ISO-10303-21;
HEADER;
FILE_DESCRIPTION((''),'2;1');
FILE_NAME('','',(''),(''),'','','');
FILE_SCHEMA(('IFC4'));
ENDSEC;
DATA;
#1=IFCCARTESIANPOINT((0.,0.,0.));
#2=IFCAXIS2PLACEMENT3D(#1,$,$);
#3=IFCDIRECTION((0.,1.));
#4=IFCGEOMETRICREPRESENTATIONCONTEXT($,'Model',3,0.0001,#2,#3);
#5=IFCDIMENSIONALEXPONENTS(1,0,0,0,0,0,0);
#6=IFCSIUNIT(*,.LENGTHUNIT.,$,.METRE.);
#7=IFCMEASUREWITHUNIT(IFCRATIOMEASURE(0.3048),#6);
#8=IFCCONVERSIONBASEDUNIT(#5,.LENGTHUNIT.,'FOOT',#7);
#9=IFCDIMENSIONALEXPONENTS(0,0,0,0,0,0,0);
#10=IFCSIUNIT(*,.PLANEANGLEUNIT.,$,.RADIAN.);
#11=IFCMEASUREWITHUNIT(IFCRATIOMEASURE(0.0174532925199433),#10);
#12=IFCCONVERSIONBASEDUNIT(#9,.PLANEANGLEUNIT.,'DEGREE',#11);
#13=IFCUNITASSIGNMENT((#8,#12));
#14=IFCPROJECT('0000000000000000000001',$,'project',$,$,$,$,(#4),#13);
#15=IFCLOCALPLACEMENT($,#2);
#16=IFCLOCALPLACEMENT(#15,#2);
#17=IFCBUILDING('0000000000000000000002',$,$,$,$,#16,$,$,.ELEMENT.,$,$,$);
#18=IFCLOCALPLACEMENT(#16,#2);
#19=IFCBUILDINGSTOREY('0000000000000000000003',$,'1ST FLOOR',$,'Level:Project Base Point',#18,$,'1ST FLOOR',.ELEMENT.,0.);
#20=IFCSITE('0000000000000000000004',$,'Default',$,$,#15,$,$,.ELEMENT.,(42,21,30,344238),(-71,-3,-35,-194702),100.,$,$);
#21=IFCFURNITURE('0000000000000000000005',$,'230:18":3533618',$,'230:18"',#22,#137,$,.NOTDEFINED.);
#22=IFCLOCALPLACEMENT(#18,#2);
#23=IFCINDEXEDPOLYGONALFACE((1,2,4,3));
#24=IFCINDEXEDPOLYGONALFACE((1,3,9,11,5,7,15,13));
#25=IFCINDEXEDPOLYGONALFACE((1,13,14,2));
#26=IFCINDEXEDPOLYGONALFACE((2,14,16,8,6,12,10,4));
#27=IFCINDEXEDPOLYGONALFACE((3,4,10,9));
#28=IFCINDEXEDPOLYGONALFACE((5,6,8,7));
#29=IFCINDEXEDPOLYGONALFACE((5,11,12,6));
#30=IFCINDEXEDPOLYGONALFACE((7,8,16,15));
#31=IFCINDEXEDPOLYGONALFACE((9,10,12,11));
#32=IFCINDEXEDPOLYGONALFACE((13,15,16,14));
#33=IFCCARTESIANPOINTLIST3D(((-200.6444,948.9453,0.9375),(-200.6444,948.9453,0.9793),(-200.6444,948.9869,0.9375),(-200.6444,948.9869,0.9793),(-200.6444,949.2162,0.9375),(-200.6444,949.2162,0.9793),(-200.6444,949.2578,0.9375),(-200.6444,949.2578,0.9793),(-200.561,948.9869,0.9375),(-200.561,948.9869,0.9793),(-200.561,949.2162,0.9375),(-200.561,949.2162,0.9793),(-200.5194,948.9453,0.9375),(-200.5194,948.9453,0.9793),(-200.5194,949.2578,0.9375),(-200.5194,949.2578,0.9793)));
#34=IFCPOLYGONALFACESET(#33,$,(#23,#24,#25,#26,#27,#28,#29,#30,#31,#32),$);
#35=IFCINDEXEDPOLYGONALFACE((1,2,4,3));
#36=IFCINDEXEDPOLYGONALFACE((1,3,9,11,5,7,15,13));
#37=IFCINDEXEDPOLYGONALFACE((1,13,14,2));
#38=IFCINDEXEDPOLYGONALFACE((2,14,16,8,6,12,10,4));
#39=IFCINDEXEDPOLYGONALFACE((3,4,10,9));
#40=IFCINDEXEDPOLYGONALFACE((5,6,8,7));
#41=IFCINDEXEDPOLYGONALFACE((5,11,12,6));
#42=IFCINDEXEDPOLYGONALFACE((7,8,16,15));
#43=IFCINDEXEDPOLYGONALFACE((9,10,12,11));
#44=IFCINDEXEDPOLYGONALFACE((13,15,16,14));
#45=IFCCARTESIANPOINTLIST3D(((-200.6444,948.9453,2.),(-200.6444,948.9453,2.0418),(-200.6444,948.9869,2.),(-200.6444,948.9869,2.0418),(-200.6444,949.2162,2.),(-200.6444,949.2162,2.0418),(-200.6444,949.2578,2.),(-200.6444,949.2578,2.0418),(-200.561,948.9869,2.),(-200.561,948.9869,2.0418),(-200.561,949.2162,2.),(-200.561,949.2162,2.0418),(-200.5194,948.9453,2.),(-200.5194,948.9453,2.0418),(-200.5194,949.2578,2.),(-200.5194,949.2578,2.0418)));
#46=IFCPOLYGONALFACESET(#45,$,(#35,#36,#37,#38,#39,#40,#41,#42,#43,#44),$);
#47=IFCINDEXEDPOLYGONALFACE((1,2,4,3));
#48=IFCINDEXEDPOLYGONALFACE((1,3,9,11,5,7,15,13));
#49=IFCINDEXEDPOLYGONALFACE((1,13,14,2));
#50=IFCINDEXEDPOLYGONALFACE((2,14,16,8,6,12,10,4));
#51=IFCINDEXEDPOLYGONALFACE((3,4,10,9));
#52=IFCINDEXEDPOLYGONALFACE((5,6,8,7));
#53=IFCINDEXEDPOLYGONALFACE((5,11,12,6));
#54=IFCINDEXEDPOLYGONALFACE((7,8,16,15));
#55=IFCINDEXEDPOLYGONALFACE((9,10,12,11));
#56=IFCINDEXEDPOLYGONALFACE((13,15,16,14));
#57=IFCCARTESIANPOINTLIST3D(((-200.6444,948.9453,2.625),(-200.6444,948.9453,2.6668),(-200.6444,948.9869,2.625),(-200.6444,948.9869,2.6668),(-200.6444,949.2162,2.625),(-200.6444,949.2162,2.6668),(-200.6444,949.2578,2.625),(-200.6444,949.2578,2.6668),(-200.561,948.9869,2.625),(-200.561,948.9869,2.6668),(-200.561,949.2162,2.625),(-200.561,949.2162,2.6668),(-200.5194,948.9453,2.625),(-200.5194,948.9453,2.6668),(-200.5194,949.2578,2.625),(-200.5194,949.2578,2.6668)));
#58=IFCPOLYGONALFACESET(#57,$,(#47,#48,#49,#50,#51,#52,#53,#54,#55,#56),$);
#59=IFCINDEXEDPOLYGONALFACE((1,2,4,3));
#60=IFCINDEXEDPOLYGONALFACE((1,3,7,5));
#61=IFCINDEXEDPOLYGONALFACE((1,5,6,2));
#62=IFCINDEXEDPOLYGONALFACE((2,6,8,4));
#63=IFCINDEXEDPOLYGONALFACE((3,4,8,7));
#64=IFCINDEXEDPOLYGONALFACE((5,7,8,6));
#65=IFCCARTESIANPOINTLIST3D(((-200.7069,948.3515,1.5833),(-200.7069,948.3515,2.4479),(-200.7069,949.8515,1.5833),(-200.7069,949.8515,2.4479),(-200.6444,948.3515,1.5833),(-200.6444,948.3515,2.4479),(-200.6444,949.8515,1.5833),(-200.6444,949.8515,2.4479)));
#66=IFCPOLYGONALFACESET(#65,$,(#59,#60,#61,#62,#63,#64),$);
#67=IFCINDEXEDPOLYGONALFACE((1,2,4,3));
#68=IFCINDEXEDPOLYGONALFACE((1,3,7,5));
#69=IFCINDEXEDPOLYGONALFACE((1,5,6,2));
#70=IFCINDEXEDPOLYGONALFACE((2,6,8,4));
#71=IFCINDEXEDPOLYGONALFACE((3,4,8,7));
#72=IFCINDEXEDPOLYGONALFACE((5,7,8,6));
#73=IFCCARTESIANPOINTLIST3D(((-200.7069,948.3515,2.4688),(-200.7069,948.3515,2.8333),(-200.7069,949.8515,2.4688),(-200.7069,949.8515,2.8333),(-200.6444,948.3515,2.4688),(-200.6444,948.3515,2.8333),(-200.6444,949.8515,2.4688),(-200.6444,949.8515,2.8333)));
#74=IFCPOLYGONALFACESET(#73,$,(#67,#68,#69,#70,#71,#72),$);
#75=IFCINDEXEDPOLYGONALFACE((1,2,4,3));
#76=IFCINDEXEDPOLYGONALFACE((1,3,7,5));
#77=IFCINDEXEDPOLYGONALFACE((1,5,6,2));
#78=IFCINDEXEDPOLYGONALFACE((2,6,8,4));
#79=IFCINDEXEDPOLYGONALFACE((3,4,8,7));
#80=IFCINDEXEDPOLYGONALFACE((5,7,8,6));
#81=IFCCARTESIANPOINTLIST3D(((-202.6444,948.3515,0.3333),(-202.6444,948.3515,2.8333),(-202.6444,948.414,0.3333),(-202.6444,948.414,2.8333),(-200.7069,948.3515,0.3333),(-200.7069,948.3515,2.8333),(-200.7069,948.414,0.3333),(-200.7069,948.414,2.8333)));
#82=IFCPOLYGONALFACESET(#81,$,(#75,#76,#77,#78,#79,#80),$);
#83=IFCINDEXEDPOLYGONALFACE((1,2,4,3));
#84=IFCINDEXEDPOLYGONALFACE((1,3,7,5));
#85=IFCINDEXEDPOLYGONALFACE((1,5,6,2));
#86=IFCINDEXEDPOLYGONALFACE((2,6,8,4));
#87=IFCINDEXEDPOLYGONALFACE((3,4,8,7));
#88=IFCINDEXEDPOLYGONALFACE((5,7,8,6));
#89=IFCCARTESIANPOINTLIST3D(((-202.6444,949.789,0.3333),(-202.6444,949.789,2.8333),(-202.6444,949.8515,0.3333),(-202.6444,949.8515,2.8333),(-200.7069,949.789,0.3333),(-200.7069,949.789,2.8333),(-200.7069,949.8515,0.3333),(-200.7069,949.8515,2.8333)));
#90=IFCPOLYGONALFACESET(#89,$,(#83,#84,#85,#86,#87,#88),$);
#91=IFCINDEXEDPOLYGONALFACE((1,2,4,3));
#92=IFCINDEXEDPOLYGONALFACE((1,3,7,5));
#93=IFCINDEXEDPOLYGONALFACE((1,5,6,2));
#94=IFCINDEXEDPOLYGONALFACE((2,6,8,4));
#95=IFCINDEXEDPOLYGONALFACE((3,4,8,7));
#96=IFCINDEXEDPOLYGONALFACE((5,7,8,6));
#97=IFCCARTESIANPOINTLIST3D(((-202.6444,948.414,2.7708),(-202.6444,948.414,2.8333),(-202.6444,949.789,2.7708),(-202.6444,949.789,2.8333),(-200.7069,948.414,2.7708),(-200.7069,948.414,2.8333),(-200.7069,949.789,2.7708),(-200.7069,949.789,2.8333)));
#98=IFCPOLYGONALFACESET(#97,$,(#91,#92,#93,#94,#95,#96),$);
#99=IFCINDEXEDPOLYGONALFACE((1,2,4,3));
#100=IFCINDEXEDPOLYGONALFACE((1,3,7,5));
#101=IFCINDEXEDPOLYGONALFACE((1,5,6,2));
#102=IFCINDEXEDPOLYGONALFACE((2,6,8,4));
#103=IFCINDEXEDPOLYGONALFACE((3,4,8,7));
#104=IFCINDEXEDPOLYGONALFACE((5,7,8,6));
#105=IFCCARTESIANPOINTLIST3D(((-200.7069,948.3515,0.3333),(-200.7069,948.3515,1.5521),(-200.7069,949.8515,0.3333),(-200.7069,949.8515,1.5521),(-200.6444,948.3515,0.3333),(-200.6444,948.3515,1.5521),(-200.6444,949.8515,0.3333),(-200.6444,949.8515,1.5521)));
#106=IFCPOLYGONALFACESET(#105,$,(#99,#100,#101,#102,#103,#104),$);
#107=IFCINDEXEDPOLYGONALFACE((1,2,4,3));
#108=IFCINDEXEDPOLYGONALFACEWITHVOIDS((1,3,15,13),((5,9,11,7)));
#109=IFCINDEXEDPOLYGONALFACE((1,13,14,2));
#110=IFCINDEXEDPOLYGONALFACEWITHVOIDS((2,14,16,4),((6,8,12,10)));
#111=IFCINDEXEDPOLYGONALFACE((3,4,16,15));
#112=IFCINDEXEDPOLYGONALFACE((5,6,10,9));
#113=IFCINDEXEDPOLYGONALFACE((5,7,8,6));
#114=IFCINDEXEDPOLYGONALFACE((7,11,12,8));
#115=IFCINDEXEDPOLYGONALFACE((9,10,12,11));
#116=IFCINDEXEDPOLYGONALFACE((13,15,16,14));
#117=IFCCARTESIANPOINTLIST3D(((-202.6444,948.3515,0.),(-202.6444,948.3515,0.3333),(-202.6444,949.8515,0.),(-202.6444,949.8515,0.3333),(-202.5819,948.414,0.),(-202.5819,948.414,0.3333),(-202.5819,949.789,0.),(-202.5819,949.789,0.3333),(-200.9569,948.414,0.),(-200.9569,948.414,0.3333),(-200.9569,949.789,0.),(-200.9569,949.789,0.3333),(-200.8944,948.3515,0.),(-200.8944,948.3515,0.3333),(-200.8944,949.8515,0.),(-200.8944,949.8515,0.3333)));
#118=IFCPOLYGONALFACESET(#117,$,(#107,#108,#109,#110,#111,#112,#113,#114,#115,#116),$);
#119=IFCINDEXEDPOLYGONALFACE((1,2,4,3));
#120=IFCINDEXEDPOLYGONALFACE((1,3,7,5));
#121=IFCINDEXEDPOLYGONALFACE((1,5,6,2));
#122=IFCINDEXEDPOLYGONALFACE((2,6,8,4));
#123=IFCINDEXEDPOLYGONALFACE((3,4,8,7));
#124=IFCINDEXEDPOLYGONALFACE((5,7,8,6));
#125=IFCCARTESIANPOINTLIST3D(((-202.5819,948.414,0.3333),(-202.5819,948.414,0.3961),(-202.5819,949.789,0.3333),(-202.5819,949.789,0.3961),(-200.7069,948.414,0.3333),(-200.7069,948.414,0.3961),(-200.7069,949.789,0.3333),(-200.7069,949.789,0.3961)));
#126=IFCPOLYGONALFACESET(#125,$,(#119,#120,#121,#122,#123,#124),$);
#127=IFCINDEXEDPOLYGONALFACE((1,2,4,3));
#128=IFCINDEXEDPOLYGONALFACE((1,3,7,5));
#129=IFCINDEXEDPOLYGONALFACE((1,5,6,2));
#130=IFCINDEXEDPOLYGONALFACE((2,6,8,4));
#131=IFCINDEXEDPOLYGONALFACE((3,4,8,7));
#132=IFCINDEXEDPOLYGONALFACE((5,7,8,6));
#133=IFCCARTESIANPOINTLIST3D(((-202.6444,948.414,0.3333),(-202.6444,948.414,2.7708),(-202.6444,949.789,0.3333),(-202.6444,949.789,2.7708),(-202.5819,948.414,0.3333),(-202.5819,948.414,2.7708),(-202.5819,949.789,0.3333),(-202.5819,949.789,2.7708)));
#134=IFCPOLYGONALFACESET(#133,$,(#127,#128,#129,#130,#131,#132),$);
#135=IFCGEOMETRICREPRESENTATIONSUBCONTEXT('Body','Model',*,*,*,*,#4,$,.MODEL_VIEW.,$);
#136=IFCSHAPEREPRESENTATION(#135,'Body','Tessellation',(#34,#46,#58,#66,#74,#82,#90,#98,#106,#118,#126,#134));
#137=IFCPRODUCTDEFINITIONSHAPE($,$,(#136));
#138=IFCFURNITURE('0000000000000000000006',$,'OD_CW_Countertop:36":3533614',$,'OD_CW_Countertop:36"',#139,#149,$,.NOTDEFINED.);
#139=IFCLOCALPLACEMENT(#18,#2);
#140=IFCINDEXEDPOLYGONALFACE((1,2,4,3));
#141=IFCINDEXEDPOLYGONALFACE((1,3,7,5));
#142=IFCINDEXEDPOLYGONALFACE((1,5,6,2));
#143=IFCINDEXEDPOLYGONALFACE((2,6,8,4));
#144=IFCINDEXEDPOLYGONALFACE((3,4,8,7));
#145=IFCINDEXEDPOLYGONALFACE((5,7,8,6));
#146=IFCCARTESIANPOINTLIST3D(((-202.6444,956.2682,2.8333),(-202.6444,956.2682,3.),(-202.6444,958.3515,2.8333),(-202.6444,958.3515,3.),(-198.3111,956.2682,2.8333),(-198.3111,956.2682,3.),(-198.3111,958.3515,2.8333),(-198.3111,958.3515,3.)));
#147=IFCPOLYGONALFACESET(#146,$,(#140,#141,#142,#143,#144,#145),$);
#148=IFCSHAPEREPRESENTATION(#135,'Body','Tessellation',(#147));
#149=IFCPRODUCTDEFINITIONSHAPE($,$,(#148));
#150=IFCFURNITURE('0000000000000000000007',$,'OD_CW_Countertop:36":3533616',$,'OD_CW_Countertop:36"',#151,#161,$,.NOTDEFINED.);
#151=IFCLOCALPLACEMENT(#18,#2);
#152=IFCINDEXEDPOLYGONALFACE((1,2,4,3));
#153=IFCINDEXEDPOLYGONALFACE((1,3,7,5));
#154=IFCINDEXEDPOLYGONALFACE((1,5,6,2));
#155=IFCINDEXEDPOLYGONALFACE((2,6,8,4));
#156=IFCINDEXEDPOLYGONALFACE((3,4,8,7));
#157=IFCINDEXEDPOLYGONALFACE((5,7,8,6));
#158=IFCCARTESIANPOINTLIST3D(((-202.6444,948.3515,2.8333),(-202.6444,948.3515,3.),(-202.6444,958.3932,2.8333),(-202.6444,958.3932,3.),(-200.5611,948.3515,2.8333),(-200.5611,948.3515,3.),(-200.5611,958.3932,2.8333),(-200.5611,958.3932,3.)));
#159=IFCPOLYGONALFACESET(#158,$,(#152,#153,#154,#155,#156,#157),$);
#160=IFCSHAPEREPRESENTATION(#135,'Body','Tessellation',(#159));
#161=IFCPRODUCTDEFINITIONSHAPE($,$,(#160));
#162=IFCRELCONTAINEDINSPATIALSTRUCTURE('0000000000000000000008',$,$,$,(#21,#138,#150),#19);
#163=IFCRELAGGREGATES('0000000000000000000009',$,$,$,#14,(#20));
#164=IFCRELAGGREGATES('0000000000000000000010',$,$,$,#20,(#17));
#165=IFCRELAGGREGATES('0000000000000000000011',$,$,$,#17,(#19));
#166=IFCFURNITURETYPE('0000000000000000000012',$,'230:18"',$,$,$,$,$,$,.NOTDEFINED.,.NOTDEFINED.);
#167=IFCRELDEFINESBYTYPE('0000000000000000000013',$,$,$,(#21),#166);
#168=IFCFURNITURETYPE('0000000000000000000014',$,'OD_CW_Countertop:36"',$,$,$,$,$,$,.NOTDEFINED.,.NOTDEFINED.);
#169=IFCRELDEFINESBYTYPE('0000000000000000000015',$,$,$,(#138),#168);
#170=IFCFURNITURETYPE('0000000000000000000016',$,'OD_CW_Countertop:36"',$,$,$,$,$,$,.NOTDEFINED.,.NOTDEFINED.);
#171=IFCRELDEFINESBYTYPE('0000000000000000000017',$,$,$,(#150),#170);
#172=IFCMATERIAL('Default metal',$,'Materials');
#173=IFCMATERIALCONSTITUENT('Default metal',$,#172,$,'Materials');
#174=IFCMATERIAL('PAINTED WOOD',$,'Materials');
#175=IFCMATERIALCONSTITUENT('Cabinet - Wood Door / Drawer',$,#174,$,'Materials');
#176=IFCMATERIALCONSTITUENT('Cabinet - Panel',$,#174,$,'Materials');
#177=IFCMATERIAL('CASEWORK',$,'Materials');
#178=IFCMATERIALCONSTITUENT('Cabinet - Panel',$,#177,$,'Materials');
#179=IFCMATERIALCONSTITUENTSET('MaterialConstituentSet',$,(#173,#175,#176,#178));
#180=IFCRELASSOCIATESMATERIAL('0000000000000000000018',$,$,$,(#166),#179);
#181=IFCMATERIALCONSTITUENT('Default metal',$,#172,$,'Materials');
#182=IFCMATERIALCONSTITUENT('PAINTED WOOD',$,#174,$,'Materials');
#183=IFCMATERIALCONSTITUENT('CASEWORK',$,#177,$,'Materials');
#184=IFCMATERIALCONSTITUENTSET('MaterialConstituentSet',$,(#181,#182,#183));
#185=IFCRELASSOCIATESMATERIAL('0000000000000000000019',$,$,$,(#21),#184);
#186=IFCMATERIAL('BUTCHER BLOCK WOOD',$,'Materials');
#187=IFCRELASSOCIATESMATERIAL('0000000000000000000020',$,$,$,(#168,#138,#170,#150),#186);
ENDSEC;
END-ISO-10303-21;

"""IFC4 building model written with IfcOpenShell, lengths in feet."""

from ifc_helpers import new_model, entity, si_unit, converted_unit, direction, frame, frame_2d, origin, origin_2d_with_axis, place, context, subcontext, project, spatial, polyline, rectangle, outline, extrude, source, transform, mapped, material, constituent, constituent_set, type_object, type_shapes, element, save


model = new_model("IFC4")

# Units and contexts
model_context = context("Model", 3, precision=0.0001, world=origin(), true_north=direction((0.0, 1.0)))
body_context = subcontext(model_context, "Body", "Model", "MODEL_VIEW")
ifc_project = project(units=[converted_unit("LENGTHUNIT", "FOOT", entity("IfcRatioMeasure", 0.3048), si_unit("LENGTHUNIT", "METRE"), dimensions=[1, 0, 0, 0, 0, 0, 0]), converted_unit("PLANEANGLEUNIT", "DEGREE", entity("IfcRatioMeasure", 0.0174532925199433), si_unit("PLANEANGLEUNIT", "RADIAN"), dimensions=[0, 0, 0, 0, 0, 0, 0])], contexts=[model_context])

# Site, building, storey
site_placement = place(None, origin())
site = spatial("IfcSite", under=ifc_project, at=site_placement, Name="Default", CompositionType="ELEMENT", RefLatitude=(42, 21, 30, 344238), RefLongitude=(-71, -3, -35, -194702), RefElevation=100.0)
building_placement = place(site_placement, origin())
building = spatial("IfcBuilding", under=site, at=building_placement, CompositionType="ELEMENT")
storey_placement = place(building_placement, origin())
storey = spatial("IfcBuildingStorey", under=building, at=storey_placement, Name="1ST FLOOR", ObjectType="Level:Project Base Point", LongName="1ST FLOOR", CompositionType="ELEMENT", Elevation=0.0)

# Shared definitions
ifc_material_1 = material(Name="Default metal", Category="Materials")
ifc_material_2 = material(Name="PAINTED WOOD", Category="Materials")
ifc_material_3 = material(Name="CASEWORK", Category="Materials")

# Furniture
ifc_constituent_1 = constituent(ifc_material_1, Name="Default metal", Category="Materials")
ifc_constituent_2 = constituent(ifc_material_2, Name="PAINTED WOOD", Category="Materials")
ifc_constituent_3 = constituent(ifc_material_3, Name="CASEWORK", Category="Materials")
ifc_constituent_set_1 = constituent_set(constituents=[ifc_constituent_1, ifc_constituent_2, ifc_constituent_3], Name="MaterialConstituentSet")
ifc_constituent_4 = constituent(ifc_material_1, Name="Default metal", Category="Materials")
ifc_constituent_5 = constituent(ifc_material_2, Name="Cabinet - Wood Door / Drawer", Category="Materials")
ifc_constituent_6 = constituent(ifc_material_2, Name="Cabinet - Panel", Category="Materials")
ifc_constituent_7 = constituent(ifc_material_3, Name="Cabinet - Panel", Category="Materials")
ifc_constituent_set_2 = constituent_set(constituents=[ifc_constituent_4, ifc_constituent_5, ifc_constituent_6, ifc_constituent_7], Name="MaterialConstituentSet")
furniture_type_1 = type_object("IfcFurnitureType", Name="230:18\"", AssemblyPlace="NOTDEFINED", PredefinedType="NOTDEFINED", material=ifc_constituent_set_2)
shared_shape_1 = source(origin(), body_context, "Body", "SweptSolid", [
    extrude(outline(polyline([(-0.0521, -0.1562), (0.0729, -0.1562), (0.0729, 0.1562), (-0.0521, 0.1562), (-0.0521, 0.1146), (0.0313, 0.1146), (0.0313, -0.1146), (-0.0521, -0.1146), (-0.0521, -0.1562)])), frame((0.0615, -2.0521, 0.9375), z_axis=(0.0, 0.0, 1.0), x_axis=(0.0, -1.0, 0.0)), (0.0, 0.0, 1.0), 0.0418),
    extrude(outline(polyline([(-0.0521, -0.1562), (0.0729, -0.1562), (0.0729, 0.1562), (-0.0521, 0.1562), (-0.0521, 0.1146), (0.0313, 0.1146), (0.0313, -0.1146), (-0.0521, -0.1146), (-0.0521, -0.1562)])), frame((0.0615, -2.0521, 2.0), z_axis=(0.0, 0.0, 1.0), x_axis=(0.0, -1.0, 0.0)), (0.0, 0.0, 1.0), 0.0418),
    extrude(outline(polyline([(-0.0521, -0.1562), (0.0729, -0.1562), (0.0729, 0.1562), (-0.0521, 0.1562), (-0.0521, 0.1146), (0.0313, 0.1146), (0.0313, -0.1146), (-0.0521, -0.1146), (-0.0521, -0.1562)])), frame((0.0615, -2.0521, 2.625), z_axis=(0.0, 0.0, 1.0), x_axis=(0.0, -1.0, 0.0)), (0.0, 0.0, 1.0), 0.0418),
    extrude(rectangle(XDim=0.0625, YDim=1.5, at=frame_2d((0.0, 0.0), x_axis=(1.0, 0.0))), frame((0.0615, -1.9688, 1.5833), z_axis=(0.0, 0.0, 1.0), x_axis=(0.0, 1.0, 0.0)), (0.0, 0.0, 1.0), 0.8646),
    extrude(rectangle(XDim=0.0625, YDim=1.5, at=frame_2d((0.0, 0.0), x_axis=(1.0, 0.0))), frame((0.0615, -1.9688, 2.4688), z_axis=(0.0, 0.0, 1.0), x_axis=(0.0, 1.0, 0.0)), (0.0, 0.0, 1.0), 0.3646),
    extrude(rectangle(XDim=0.0625, YDim=1.9375, at=frame_2d((0.0, 0.0), x_axis=(1.0, 0.0))), frame((-0.6573, -0.9687, 0.3333)), (0.0, 0.0, 1.0), 2.5),
    extrude(rectangle(XDim=0.0625, YDim=1.9375, at=frame_2d((0.0, 0.0), x_axis=(1.0, 0.0))), frame((0.7802, -0.9687, 0.3333)), (0.0, 0.0, 1.0), 2.5),
    extrude(rectangle(XDim=1.375, YDim=1.9375, at=origin_2d_with_axis()), frame((0.0615, -0.9687, 2.7708), z_axis=(0.0, 0.0, 1.0), x_axis=(-1.0, 0.0, 0.0)), (0.0, 0.0, 1.0), 0.0625),
    extrude(rectangle(XDim=0.0625, YDim=1.5, at=frame_2d((0.0, 0.0), x_axis=(1.0, 0.0))), frame((0.0615, -1.9688, 0.3333), z_axis=(0.0, 0.0, 1.0), x_axis=(0.0, 1.0, 0.0)), (0.0, 0.0, 1.0), 1.2187),
    extrude(outline(polyline([(-0.75, -0.875), (0.75, -0.875), (0.75, 0.875), (-0.75, 0.875), (-0.75, -0.875)]), holes=[polyline([(-0.6875, -0.8125), (-0.6875, 0.8125), (0.6875, 0.8125), (0.6875, -0.8125), (-0.6875, -0.8125)])]), frame((0.0615, -0.875, 0.0)), (0.0, 0.0, 1.0), 0.3333),
    extrude(rectangle(XDim=1.375, YDim=1.875, at=frame_2d((0.0, 0.0), x_axis=(1.0, 0.0))), frame((0.0615, -1.0, 0.3333), z_axis=(0.0, 0.0, 1.0), x_axis=(-1.0, 0.0, 0.0)), (0.0, 0.0, 1.0), 0.0627),
    extrude(rectangle(XDim=0.0625, YDim=1.375, at=origin_2d_with_axis()), frame((0.0615, -0.0312, 0.3333), z_axis=(0.0, 0.0, 1.0), x_axis=(0.0, 1.0, 0.0)), (0.0, 0.0, 1.0), 2.4375),
])
type_shapes(furniture_type_1, [shared_shape_1])
furniture_1_placement = place(storey_placement, frame((-202.6444, 949.04, 0.0), z_axis=(0.0, 0.0, 1.0), x_axis=(0.0, 1.0, 0.0)))
element("IfcFurniture", 1, at=furniture_1_placement, inside=storey, type_object=furniture_type_1, material=ifc_constituent_set_1, Name="230:18\":3533618", ObjectType="230:18\"", PredefinedType="NOTDEFINED", context=body_context, shape_type="MappedRepresentation", body=[
    mapped(shared_shape_1, transform((0.0, 0.0, 0.0), scale=1.0)),
])
ifc_material_4 = material(Name="BUTCHER BLOCK WOOD", Category="Materials")
furniture_type_2 = type_object("IfcFurnitureType", Name="OD_CW_Countertop:36\"", AssemblyPlace="NOTDEFINED", PredefinedType="NOTDEFINED", material=ifc_material_4)
shared_shape_2 = source(origin(), body_context, "Body", "SweptSolid", [
    extrude(rectangle(XDim=4.3333, YDim=2.0833, at=origin_2d_with_axis()), frame((2.1667, 1.0417, 0.0)), (0.0, 0.0, 1.0), 0.1667),
])
type_shapes(furniture_type_2, [shared_shape_2])
furniture_2_placement = place(storey_placement, frame((-198.3111, 958.3515, 2.8333), z_axis=(0.0, 0.0, 1.0), x_axis=(-1.0, 0.0, 0.0)))
element("IfcFurniture", 2, at=furniture_2_placement, inside=storey, type_object=furniture_type_2, material=ifc_material_4, Name="OD_CW_Countertop:36\":3533614", ObjectType="OD_CW_Countertop:36\"", PredefinedType="NOTDEFINED", context=body_context, shape_type="MappedRepresentation", body=[
    mapped(shared_shape_2, transform((0.0, 0.0, 0.0), scale=1.0)),
])
furniture_type_3 = type_object("IfcFurnitureType", Name="OD_CW_Countertop:36\"", AssemblyPlace="NOTDEFINED", PredefinedType="NOTDEFINED", material=ifc_material_4)
shared_shape_3 = source(origin(), body_context, "Body", "SweptSolid", [
    extrude(rectangle(XDim=10.0417, YDim=2.0833, at=origin_2d_with_axis()), frame((5.0208, 1.0417, 0.0)), (0.0, 0.0, 1.0), 0.1667),
])
type_shapes(furniture_type_3, [shared_shape_3])
furniture_3_placement = place(storey_placement, frame((-202.6444, 958.3932, 2.8333), z_axis=(0.0, 0.0, 1.0), x_axis=(0.0, -1.0, 0.0)))
element("IfcFurniture", 3, at=furniture_3_placement, inside=storey, type_object=furniture_type_3, material=ifc_material_4, Name="OD_CW_Countertop:36\":3533616", ObjectType="OD_CW_Countertop:36\"", PredefinedType="NOTDEFINED", context=body_context, shape_type="MappedRepresentation", body=[
    mapped(shared_shape_3, transform((0.0, 0.0, 0.0), scale=1.0)),
])

save(model, "model.ifc")
